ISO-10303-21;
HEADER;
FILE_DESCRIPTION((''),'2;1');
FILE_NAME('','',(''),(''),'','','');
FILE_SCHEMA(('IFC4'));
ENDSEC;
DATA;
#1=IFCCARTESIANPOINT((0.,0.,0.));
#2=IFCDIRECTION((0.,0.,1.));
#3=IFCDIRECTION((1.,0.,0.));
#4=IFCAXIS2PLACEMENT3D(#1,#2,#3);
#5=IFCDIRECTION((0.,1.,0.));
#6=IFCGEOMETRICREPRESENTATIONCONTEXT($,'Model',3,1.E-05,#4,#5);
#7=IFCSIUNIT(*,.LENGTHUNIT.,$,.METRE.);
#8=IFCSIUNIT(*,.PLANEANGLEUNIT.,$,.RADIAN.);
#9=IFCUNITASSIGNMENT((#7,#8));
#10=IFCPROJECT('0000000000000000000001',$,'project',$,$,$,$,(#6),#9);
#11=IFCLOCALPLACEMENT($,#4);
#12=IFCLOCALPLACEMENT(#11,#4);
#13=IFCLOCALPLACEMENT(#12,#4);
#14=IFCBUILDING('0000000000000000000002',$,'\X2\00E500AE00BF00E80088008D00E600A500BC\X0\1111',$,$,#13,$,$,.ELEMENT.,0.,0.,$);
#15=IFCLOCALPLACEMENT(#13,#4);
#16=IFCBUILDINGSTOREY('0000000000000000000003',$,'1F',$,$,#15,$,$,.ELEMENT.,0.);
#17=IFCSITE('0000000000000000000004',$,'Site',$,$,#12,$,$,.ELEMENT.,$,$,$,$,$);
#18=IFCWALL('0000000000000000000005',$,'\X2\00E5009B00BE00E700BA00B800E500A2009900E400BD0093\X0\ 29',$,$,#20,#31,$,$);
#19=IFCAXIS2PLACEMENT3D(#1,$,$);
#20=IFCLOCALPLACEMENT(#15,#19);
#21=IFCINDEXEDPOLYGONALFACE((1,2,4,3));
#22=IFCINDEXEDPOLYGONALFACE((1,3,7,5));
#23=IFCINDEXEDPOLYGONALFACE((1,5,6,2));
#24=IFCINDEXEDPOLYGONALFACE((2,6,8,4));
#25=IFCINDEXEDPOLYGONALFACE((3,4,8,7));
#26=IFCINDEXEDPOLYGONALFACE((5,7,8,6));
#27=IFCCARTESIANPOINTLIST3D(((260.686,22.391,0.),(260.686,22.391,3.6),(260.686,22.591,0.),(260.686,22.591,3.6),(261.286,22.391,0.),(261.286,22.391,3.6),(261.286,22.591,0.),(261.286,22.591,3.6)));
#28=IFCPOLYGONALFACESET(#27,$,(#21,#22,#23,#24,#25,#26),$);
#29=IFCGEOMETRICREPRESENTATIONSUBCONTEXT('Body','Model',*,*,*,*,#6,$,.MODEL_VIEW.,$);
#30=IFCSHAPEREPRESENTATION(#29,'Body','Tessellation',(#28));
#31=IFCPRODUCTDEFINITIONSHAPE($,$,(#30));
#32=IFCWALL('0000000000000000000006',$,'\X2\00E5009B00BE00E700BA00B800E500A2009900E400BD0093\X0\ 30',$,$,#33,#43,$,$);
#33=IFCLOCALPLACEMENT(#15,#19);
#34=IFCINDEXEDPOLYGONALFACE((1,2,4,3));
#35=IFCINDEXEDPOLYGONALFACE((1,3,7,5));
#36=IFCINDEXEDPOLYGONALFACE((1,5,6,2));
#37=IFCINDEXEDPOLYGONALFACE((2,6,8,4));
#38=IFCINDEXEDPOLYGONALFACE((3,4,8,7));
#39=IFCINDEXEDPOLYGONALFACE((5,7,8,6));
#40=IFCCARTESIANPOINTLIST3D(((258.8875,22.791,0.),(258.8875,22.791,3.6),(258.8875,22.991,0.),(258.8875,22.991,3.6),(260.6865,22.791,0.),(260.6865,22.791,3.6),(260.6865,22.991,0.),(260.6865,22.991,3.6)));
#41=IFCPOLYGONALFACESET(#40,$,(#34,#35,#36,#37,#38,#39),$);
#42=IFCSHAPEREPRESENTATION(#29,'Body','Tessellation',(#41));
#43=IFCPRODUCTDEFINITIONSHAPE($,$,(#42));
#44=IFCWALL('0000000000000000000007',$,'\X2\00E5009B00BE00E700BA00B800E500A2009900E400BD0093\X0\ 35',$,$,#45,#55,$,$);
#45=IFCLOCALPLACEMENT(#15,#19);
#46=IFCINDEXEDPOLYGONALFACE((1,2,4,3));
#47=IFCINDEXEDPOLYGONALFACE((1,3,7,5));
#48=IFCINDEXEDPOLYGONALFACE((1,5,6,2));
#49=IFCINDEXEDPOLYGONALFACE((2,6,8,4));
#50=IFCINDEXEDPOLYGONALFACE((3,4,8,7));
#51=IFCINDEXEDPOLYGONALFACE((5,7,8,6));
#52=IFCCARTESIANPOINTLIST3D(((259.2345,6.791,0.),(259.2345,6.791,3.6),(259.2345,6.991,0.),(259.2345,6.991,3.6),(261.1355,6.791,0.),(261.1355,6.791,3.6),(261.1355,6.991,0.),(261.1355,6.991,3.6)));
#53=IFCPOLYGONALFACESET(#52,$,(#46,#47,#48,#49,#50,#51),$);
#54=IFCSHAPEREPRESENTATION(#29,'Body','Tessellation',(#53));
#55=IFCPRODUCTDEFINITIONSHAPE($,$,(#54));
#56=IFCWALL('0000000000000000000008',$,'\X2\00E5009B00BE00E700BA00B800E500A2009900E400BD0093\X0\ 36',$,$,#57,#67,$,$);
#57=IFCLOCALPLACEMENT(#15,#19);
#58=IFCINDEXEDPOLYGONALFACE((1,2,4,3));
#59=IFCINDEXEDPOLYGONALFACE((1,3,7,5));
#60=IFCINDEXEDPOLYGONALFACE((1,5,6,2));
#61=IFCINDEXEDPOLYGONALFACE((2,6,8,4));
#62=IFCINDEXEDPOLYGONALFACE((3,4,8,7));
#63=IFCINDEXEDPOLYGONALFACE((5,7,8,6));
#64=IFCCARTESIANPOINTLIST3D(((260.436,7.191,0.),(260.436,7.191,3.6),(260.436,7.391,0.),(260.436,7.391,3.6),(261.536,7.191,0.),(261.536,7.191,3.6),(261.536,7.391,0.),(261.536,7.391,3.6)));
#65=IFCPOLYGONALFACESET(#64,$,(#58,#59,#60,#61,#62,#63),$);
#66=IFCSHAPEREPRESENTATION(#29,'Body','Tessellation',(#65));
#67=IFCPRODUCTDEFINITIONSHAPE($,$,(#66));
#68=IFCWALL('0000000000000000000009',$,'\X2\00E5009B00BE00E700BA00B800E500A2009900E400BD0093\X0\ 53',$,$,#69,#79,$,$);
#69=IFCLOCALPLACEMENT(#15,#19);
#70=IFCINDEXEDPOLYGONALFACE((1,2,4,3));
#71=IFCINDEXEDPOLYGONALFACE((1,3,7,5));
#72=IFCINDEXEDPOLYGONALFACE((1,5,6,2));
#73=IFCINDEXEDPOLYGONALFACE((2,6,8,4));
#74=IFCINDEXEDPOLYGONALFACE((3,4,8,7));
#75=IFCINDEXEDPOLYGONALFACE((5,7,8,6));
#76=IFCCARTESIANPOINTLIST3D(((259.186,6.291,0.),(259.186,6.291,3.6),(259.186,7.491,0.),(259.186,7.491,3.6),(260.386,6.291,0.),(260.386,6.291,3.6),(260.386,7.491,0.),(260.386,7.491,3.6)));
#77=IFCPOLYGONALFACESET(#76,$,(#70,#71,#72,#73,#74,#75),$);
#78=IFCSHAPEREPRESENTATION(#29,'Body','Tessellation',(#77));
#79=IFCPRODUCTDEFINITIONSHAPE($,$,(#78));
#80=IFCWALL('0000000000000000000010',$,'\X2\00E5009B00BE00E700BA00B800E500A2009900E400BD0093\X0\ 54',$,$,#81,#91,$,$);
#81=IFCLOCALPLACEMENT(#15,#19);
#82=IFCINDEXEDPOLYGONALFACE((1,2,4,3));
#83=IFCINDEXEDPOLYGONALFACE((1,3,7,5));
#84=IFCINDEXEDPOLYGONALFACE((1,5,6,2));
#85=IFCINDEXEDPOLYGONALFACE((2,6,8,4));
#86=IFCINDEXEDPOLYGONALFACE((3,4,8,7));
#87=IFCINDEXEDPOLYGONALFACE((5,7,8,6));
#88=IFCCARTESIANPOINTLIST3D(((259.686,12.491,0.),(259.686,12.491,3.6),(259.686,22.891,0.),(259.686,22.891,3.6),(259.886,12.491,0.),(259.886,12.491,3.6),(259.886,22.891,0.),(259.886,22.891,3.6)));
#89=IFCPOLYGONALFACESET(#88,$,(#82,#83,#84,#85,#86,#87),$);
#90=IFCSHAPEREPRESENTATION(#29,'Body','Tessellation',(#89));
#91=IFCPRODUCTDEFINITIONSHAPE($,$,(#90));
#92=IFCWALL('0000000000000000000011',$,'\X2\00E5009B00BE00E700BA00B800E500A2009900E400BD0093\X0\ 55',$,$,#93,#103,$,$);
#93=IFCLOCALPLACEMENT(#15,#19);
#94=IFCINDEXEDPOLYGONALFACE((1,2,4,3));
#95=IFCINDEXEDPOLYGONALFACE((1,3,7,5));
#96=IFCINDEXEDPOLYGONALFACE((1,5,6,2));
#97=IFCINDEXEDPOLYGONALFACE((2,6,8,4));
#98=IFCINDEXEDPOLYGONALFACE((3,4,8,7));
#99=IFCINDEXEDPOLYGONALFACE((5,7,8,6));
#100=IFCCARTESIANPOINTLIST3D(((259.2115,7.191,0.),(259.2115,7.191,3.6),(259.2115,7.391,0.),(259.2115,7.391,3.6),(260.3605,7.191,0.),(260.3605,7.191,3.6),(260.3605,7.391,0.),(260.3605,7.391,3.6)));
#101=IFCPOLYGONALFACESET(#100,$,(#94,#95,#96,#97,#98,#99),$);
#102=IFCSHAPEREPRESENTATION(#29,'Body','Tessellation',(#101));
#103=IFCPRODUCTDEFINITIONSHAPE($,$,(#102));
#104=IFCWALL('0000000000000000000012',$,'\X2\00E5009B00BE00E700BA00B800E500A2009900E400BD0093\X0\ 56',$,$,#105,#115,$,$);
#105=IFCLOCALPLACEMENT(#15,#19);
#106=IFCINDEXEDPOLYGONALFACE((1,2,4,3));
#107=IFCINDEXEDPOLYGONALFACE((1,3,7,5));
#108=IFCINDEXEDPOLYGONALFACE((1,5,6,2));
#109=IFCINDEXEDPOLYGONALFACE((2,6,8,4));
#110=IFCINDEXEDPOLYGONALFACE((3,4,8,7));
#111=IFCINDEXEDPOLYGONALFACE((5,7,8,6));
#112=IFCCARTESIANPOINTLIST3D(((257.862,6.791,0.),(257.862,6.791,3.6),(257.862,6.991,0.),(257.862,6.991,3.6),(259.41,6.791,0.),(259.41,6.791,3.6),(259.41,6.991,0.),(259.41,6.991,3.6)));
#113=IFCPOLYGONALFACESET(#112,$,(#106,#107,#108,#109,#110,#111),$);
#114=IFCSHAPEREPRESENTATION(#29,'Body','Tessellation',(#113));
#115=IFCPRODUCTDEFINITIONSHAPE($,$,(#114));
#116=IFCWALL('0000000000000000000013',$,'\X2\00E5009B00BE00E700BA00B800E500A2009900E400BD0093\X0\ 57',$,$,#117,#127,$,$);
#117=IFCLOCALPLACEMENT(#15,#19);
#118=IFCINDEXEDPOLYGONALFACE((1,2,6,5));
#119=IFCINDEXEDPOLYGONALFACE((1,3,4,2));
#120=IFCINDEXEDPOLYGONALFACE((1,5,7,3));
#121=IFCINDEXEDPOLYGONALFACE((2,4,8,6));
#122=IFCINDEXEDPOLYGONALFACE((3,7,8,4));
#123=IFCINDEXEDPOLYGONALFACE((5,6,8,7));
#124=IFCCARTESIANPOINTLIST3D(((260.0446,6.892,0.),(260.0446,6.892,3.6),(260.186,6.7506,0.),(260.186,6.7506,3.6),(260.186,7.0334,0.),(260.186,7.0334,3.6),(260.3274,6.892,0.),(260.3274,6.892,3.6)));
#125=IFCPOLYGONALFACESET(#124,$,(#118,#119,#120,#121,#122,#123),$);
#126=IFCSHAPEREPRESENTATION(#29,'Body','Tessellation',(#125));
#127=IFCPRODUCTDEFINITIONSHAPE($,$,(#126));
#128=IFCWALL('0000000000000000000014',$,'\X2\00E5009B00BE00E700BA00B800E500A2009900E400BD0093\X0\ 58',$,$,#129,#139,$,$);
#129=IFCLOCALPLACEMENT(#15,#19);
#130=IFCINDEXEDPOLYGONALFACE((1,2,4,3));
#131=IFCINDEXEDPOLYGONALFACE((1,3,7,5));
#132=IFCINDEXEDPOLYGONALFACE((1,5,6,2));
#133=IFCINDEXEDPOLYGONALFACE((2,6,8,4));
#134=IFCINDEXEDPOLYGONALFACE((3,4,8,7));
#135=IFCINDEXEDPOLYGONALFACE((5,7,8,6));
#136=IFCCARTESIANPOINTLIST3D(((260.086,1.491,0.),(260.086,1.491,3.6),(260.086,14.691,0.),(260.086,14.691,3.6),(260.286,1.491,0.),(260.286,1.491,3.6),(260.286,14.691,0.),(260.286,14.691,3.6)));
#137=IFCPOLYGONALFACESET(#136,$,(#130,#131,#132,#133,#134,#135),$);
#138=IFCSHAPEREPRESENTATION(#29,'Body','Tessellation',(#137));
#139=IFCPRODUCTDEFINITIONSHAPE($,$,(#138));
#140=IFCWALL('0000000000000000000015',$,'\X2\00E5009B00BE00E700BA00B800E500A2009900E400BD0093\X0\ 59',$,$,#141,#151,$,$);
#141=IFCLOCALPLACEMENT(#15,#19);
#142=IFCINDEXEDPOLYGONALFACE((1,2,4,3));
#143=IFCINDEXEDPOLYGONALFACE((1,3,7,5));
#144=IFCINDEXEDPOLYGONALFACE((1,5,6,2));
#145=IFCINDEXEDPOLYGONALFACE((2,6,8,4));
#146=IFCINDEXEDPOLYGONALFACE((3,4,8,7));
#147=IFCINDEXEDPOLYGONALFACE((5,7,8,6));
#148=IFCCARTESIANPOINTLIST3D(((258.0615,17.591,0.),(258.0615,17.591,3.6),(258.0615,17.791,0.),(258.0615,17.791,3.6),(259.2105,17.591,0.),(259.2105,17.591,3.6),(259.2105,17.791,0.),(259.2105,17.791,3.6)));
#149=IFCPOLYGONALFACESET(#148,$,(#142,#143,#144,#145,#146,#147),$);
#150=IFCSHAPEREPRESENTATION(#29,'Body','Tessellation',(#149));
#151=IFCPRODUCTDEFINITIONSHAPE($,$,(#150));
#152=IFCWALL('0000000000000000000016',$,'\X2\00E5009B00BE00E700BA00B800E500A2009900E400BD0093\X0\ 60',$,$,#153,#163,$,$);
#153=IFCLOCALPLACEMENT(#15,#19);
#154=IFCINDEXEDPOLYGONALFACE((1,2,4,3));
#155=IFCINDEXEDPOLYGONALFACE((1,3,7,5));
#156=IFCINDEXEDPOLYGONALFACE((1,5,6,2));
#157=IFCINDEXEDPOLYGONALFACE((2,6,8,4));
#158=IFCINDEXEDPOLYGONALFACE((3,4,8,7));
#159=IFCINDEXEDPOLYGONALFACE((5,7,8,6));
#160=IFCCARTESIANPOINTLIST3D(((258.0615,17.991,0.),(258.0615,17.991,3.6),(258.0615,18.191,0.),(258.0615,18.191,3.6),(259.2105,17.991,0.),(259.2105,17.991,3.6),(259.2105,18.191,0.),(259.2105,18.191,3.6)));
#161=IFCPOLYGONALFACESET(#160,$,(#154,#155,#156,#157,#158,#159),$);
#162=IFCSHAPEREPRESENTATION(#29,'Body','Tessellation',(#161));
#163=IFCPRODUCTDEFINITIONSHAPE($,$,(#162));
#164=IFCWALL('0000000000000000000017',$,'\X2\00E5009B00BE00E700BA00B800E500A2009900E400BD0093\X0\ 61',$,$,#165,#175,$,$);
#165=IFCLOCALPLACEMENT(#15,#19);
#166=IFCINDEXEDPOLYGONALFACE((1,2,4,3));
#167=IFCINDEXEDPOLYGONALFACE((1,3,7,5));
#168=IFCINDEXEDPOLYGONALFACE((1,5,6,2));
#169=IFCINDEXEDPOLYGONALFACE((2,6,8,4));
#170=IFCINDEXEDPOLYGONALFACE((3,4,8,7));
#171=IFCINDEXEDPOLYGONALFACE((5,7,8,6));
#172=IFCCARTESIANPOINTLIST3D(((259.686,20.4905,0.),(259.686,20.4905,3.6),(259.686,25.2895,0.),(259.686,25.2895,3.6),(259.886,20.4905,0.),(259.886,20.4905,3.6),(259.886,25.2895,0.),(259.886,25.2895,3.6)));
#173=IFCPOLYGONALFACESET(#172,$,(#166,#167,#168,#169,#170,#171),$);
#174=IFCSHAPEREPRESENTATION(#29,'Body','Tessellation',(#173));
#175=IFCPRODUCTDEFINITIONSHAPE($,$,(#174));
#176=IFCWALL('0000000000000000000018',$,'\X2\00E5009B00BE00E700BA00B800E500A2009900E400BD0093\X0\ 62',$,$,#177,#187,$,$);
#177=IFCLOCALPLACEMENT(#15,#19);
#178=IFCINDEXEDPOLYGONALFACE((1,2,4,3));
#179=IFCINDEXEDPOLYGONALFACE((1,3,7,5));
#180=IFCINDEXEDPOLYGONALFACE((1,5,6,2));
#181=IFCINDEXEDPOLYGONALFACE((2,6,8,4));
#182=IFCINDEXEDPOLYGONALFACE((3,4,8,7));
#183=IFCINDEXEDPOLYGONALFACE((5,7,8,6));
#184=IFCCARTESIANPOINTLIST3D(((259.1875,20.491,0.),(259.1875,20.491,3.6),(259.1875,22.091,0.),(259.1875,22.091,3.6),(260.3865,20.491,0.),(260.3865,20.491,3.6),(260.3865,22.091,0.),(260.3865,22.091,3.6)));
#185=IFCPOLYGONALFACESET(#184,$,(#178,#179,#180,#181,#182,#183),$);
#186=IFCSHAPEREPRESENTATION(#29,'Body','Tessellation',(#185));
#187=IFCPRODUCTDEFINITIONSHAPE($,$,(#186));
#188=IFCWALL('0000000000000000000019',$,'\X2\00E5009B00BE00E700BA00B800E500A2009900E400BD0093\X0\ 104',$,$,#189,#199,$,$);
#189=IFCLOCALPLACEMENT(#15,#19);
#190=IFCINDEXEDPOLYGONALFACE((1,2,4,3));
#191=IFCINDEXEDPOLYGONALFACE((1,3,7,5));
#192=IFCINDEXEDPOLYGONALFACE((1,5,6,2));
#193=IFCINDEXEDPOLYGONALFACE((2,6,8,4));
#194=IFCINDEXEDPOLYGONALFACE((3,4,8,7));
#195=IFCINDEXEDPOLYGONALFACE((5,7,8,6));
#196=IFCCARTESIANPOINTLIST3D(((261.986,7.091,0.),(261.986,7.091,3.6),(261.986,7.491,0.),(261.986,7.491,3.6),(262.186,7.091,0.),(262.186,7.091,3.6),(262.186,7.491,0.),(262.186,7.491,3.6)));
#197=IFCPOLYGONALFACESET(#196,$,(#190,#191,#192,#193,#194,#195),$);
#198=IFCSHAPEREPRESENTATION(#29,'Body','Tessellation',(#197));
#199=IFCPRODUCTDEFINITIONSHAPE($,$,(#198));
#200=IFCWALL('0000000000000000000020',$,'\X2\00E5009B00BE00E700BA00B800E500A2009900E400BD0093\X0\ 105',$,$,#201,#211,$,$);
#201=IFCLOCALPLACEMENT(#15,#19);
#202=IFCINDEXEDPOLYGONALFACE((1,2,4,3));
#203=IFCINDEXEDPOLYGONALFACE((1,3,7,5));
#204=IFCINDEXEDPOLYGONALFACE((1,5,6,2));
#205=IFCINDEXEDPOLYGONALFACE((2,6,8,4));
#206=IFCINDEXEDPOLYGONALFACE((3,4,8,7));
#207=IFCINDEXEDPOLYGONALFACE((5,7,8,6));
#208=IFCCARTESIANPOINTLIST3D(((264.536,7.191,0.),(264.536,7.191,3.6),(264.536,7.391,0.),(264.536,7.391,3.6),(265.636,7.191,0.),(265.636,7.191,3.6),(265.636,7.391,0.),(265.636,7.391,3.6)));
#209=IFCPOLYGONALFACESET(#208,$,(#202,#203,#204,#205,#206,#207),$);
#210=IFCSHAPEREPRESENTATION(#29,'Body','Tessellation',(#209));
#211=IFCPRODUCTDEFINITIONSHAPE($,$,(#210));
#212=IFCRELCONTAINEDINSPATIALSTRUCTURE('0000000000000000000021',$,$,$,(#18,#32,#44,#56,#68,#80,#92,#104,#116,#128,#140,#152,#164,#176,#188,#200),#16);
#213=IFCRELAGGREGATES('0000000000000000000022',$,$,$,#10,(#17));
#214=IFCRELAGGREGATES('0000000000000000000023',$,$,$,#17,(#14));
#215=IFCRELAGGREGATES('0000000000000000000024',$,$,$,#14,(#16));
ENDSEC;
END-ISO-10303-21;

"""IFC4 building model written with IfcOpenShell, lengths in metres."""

from ifc_helpers import new_model, si_unit, direction, frame, frame_2d, origin_with_axes, place, context, subcontext, project, spatial, rectangle, extrude, element, save


model = new_model("IFC4")

# Units and contexts
model_context = context("Model", 3, precision=1e-05, world=origin_with_axes(), true_north=direction((0.0, 1.0, 0.0)))
body_context = subcontext(model_context, "Body", "Model", "MODEL_VIEW")
ifc_project = project(units=[si_unit("LENGTHUNIT", "METRE"), si_unit("PLANEANGLEUNIT", "RADIAN")], contexts=[model_context])

# Site, building, storey
placement = place(None, origin_with_axes())
site_placement = place(placement, origin_with_axes())
site = spatial("IfcSite", under=ifc_project, at=site_placement, Name="Site", CompositionType="ELEMENT")
building_placement = place(site_placement, origin_with_axes())
building = spatial("IfcBuilding", under=site, at=building_placement, Name="å®¿è\u0088\u008dæ¥¼1111", CompositionType="ELEMENT", ElevationOfRefHeight=0.0, ElevationOfTerrain=0.0)
storey_placement = place(building_placement, origin_with_axes())
storey = spatial("IfcBuildingStorey", under=building, at=storey_placement, Name="1F", CompositionType="ELEMENT", Elevation=0.0)

# Walls
wall_1_placement = place(storey_placement, frame((260.986, 22.491, 0.0), z_axis=(0.0, 0.0, 1.0), x_axis=(1.0, 0.0, 0.0)))
element("IfcWall", 1, at=wall_1_placement, inside=storey, Name="å\u009b¾çº¸å¢\u0099ä½\u0093 29", context=body_context, shape_type="SweptSolid", body=[
    extrude(rectangle(XDim=0.6, YDim=0.2, at=frame_2d((0.0, 0.0), x_axis=(1.0, 0.0, 0.0))), frame((0.0, 0.0, 0.0), z_axis=(0.0, 0.0, 1.0)), (0.0, 0.0, 1.0), 3.6),
])
wall_2_placement = place(storey_placement, frame((259.787, 22.891, 0.0), z_axis=(0.0, 0.0, 1.0), x_axis=(1.0, 0.0, 0.0)))
element("IfcWall", 2, at=wall_2_placement, inside=storey, Name="å\u009b¾çº¸å¢\u0099ä½\u0093 30", context=body_context, shape_type="SweptSolid", body=[
    extrude(rectangle(XDim=1.799, YDim=0.2, at=frame_2d((0.0, 0.0), x_axis=(1.0, 0.0, 0.0))), frame((0.0, 0.0, 0.0), z_axis=(0.0, 0.0, 1.0)), (0.0, 0.0, 1.0), 3.6),
])
wall_3_placement = place(storey_placement, frame((260.185, 6.891, 0.0), z_axis=(0.0, 0.0, 1.0), x_axis=(1.0, 0.0, 0.0)))
element("IfcWall", 3, at=wall_3_placement, inside=storey, Name="å\u009b¾çº¸å¢\u0099ä½\u0093 35", context=body_context, shape_type="SweptSolid", body=[
    extrude(rectangle(XDim=1.901, YDim=0.2, at=frame_2d((0.0, 0.0), x_axis=(1.0, 0.0, 0.0))), frame((0.0, 0.0, 0.0), z_axis=(0.0, 0.0, 1.0)), (0.0, 0.0, 1.0), 3.6),
])
wall_4_placement = place(storey_placement, frame((260.986, 7.291, 0.0), z_axis=(0.0, 0.0, 1.0), x_axis=(1.0, 0.0, 0.0)))
element("IfcWall", 4, at=wall_4_placement, inside=storey, Name="å\u009b¾çº¸å¢\u0099ä½\u0093 36", context=body_context, shape_type="SweptSolid", body=[
    extrude(rectangle(XDim=1.1, YDim=0.2, at=frame_2d((0.0, 0.0), x_axis=(1.0, 0.0, 0.0))), frame((0.0, 0.0, 0.0), z_axis=(0.0, 0.0, 1.0)), (0.0, 0.0, 1.0), 3.6),
])
wall_5_placement = place(storey_placement, frame((259.786, 6.891, 0.0), z_axis=(0.0, 0.0, 1.0), x_axis=(1.0, 0.0, 0.0)))
element("IfcWall", 5, at=wall_5_placement, inside=storey, Name="å\u009b¾çº¸å¢\u0099ä½\u0093 53", context=body_context, shape_type="SweptSolid", body=[
    extrude(rectangle(XDim=1.2, YDim=1.2, at=frame_2d((0.0, 0.0), x_axis=(1.0, 0.0, 0.0))), frame((0.0, 0.0, 0.0), z_axis=(0.0, 0.0, 1.0)), (0.0, 0.0, 1.0), 3.6),
])
wall_6_placement = place(storey_placement, frame((259.786, 17.691, 0.0), z_axis=(0.0, 0.0, 1.0), x_axis=(0.0, -1.0, 0.0)))
element("IfcWall", 6, at=wall_6_placement, inside=storey, Name="å\u009b¾çº¸å¢\u0099ä½\u0093 54", context=body_context, shape_type="SweptSolid", body=[
    extrude(rectangle(XDim=10.4, YDim=0.2, at=frame_2d((0.0, 0.0), x_axis=(1.0, 0.0, 0.0))), frame((0.0, 0.0, 0.0), z_axis=(0.0, 0.0, 1.0)), (0.0, 0.0, 1.0), 3.6),
])
wall_7_placement = place(storey_placement, frame((259.786, 7.291, 0.0), z_axis=(0.0, 0.0, 1.0), x_axis=(-1.0, 0.0, 0.0)))
element("IfcWall", 7, at=wall_7_placement, inside=storey, Name="å\u009b¾çº¸å¢\u0099ä½\u0093 55", context=body_context, shape_type="SweptSolid", body=[
    extrude(rectangle(XDim=1.149, YDim=0.2, at=frame_2d((0.0, 0.0), x_axis=(1.0, 0.0, 0.0))), frame((0.0, 0.0, 0.0), z_axis=(0.0, 0.0, 1.0)), (0.0, 0.0, 1.0), 3.6),
])
wall_8_placement = place(storey_placement, frame((258.636, 6.891, 0.0), z_axis=(0.0, 0.0, 1.0), x_axis=(1.0, 0.0, 0.0)))
element("IfcWall", 8, at=wall_8_placement, inside=storey, Name="å\u009b¾çº¸å¢\u0099ä½\u0093 56", context=body_context, shape_type="SweptSolid", body=[
    extrude(rectangle(XDim=1.548, YDim=0.2, at=frame_2d((0.0, 0.0), x_axis=(1.0, 0.0, 0.0))), frame((0.0, 0.0, 0.0), z_axis=(0.0, 0.0, 1.0)), (0.0, 0.0, 1.0), 3.6),
])
wall_9_placement = place(storey_placement, frame((260.186, 6.892, 0.0), z_axis=(0.0, 0.0, 1.0), x_axis=(-0.707107, -0.707107, 0.0)))
element("IfcWall", 9, at=wall_9_placement, inside=storey, Name="å\u009b¾çº¸å¢\u0099ä½\u0093 57", context=body_context, shape_type="SweptSolid", body=[
    extrude(rectangle(XDim=0.2, YDim=0.2, at=frame_2d((0.0, 0.0), x_axis=(1.0, 0.0, 0.0))), frame((0.0, 0.0, 0.0), z_axis=(0.0, 0.0, 1.0)), (0.0, 0.0, 1.0), 3.6),
])
wall_10_placement = place(storey_placement, frame((260.186, 8.091, 0.0), z_axis=(0.0, 0.0, 1.0), x_axis=(0.0, 1.0, 0.0)))
element("IfcWall", 10, at=wall_10_placement, inside=storey, Name="å\u009b¾çº¸å¢\u0099ä½\u0093 58", context=body_context, shape_type="SweptSolid", body=[
    extrude(rectangle(XDim=13.2, YDim=0.2, at=frame_2d((0.0, 0.0), x_axis=(1.0, 0.0, 0.0))), frame((0.0, 0.0, 0.0), z_axis=(0.0, 0.0, 1.0)), (0.0, 0.0, 1.0), 3.6),
])
for number, where, z_axis, x_axis, name in (
    (11, (258.636, 17.691, 0.0), (0.0, 0.0, 1.0), (1.0, 0.0, 0.0), "å\u009b¾çº¸å¢\u0099ä½\u0093 59"),
    (12, (258.636, 18.091, 0.0), (0.0, 0.0, 1.0), (1.0, 0.0, 0.0), "å\u009b¾çº¸å¢\u0099ä½\u0093 60"),
):
    element("IfcWall", number, at=place(storey_placement, frame(where, z_axis=z_axis, x_axis=x_axis)), inside=storey, Name=name, context=body_context, shape_type="SweptSolid", body=[
        extrude(rectangle(XDim=1.149, YDim=0.2, at=frame_2d((0.0, 0.0), x_axis=(1.0, 0.0, 0.0))), frame((0.0, 0.0, 0.0), z_axis=(0.0, 0.0, 1.0)), (0.0, 0.0, 1.0), 3.6),
    ])
wall_11_placement = place(storey_placement, frame((259.786, 22.89, 0.0), z_axis=(0.0, 0.0, 1.0), x_axis=(0.0, -1.0, 0.0)))
element("IfcWall", 13, at=wall_11_placement, inside=storey, Name="å\u009b¾çº¸å¢\u0099ä½\u0093 61", context=body_context, shape_type="SweptSolid", body=[
    extrude(rectangle(XDim=4.799, YDim=0.2, at=frame_2d((0.0, 0.0), x_axis=(1.0, 0.0, 0.0))), frame((0.0, 0.0, 0.0), z_axis=(0.0, 0.0, 1.0)), (0.0, 0.0, 1.0), 3.6),
])
wall_12_placement = place(storey_placement, frame((259.787, 21.291, 0.0), z_axis=(0.0, 0.0, 1.0), x_axis=(1.0, 0.0, 0.0)))
element("IfcWall", 14, at=wall_12_placement, inside=storey, Name="å\u009b¾çº¸å¢\u0099ä½\u0093 62", context=body_context, shape_type="SweptSolid", body=[
    extrude(rectangle(XDim=1.199, YDim=1.6, at=frame_2d((0.0, 0.0), x_axis=(1.0, 0.0, 0.0))), frame((0.0, 0.0, 0.0), z_axis=(0.0, 0.0, 1.0)), (0.0, 0.0, 1.0), 3.6),
])
wall_13_placement = place(storey_placement, frame((262.086, 7.291, 0.0), z_axis=(0.0, 0.0, 1.0), x_axis=(0.0, -1.0, 0.0)))
element("IfcWall", 15, at=wall_13_placement, inside=storey, Name="å\u009b¾çº¸å¢\u0099ä½\u0093 104", context=body_context, shape_type="SweptSolid", body=[
    extrude(rectangle(XDim=0.4, YDim=0.2, at=frame_2d((0.0, 0.0), x_axis=(1.0, 0.0, 0.0))), frame((0.0, 0.0, 0.0), z_axis=(0.0, 0.0, 1.0)), (0.0, 0.0, 1.0), 3.6),
])
wall_14_placement = place(storey_placement, frame((265.086, 7.291, 0.0), z_axis=(0.0, 0.0, 1.0), x_axis=(1.0, 0.0, 0.0)))
element("IfcWall", 16, at=wall_14_placement, inside=storey, Name="å\u009b¾çº¸å¢\u0099ä½\u0093 105", context=body_context, shape_type="SweptSolid", body=[
    extrude(rectangle(XDim=1.1, YDim=0.2, at=frame_2d((0.0, 0.0), x_axis=(1.0, 0.0, 0.0))), frame((0.0, 0.0, 0.0), z_axis=(0.0, 0.0, 1.0)), (0.0, 0.0, 1.0), 3.6),
])

save(model, "model.ifc")
